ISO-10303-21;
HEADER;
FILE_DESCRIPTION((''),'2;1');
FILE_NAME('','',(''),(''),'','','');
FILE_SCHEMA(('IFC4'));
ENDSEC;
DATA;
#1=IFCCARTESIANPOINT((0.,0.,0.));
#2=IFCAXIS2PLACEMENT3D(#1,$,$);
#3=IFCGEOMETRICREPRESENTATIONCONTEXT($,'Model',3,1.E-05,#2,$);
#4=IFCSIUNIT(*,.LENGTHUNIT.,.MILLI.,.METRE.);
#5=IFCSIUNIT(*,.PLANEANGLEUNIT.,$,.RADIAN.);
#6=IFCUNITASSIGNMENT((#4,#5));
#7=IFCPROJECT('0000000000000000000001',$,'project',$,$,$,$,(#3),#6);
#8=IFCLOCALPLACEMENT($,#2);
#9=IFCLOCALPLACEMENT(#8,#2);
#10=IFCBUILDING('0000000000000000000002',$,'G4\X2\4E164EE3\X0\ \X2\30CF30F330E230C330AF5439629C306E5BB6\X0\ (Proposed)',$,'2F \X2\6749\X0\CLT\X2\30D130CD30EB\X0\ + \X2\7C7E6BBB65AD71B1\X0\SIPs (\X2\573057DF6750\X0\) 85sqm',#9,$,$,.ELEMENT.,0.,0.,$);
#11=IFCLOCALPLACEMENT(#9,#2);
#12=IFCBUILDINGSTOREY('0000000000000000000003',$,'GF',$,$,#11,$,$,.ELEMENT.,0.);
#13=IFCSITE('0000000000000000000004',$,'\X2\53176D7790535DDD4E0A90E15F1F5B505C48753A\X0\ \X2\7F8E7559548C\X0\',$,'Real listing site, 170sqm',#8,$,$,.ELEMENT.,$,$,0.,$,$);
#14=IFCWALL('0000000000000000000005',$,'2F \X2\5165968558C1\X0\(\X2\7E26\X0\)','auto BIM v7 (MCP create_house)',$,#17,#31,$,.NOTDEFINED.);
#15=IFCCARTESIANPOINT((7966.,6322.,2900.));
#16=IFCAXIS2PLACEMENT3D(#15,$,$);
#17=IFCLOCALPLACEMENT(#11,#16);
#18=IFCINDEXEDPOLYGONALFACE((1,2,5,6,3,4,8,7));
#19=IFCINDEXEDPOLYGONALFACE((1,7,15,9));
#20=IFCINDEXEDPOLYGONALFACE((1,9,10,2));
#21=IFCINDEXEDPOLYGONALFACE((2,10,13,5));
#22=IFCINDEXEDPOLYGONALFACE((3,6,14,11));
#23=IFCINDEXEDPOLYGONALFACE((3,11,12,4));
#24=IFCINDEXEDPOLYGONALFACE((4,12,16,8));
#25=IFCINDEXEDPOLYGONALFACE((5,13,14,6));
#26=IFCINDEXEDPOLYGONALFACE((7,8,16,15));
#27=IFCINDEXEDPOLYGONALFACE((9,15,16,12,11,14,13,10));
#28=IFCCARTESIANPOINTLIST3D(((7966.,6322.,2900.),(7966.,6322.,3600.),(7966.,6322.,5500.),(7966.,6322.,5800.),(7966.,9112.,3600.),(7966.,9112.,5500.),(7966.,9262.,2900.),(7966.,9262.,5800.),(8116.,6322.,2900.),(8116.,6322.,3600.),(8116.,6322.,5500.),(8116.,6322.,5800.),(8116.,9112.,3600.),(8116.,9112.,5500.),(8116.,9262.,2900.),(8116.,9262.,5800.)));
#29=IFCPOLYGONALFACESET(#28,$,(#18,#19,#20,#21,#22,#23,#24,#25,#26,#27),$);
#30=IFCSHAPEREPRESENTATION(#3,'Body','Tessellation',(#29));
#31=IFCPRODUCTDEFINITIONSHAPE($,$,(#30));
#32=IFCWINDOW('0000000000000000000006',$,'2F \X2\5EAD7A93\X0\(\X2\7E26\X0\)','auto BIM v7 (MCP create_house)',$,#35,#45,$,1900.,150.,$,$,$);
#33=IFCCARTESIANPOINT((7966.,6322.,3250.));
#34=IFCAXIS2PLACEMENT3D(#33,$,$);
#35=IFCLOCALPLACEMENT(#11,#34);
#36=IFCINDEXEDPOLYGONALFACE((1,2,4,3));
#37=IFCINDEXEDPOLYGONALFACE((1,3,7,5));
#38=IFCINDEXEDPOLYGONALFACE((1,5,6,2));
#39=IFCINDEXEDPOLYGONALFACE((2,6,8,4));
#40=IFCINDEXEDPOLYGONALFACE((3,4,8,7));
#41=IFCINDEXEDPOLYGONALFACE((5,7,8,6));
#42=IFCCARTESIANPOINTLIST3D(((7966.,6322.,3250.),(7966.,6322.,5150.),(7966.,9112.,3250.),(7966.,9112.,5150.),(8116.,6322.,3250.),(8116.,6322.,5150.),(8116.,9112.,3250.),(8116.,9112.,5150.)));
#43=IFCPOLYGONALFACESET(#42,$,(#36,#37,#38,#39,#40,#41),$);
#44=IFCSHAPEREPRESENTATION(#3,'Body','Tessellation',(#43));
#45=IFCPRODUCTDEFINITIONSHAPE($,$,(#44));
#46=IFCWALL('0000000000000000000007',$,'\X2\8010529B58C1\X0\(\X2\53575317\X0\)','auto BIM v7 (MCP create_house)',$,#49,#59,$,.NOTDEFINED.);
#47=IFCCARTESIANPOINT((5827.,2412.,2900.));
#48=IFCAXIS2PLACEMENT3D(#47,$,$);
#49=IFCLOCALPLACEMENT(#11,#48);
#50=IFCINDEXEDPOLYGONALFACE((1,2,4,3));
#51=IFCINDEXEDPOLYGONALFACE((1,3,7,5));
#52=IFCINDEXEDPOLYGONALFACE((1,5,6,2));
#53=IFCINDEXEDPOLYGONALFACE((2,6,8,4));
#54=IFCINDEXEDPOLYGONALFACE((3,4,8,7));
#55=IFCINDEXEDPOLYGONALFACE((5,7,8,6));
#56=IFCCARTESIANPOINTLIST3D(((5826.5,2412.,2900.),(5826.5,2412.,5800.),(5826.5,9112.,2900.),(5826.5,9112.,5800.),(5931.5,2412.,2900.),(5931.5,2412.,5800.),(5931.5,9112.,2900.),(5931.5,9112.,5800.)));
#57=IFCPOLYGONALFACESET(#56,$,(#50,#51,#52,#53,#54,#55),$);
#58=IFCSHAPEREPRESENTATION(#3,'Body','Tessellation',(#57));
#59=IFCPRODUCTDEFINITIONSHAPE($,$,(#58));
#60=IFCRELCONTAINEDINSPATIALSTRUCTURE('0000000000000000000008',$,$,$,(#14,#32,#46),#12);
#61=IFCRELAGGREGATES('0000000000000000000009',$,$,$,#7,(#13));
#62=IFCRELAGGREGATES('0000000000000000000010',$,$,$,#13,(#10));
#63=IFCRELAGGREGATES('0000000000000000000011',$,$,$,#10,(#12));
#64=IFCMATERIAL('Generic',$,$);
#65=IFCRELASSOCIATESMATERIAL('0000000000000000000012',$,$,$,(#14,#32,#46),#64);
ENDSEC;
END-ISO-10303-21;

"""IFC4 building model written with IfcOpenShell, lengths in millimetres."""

from ifc_helpers import new_model, si_unit, frame, frame_2d, origin, place, context, project, spatial, rectangle, extrude, material, element, fill, save


model = new_model("IFC4")

# Units and contexts
model_context = context("Model", 3, precision=1e-05, world=origin())
ifc_project = project(units=[si_unit("LENGTHUNIT", "METRE", prefix="MILLI"), si_unit("PLANEANGLEUNIT", "RADIAN")], contexts=[model_context])

# Site, building, storey
site_placement = place(None, origin())
site = spatial("IfcSite", under=ifc_project, at=site_placement, Name="北海道川上郡弟子屈町 美留和", ObjectType="Real listing site, 170sqm", CompositionType="ELEMENT", RefElevation=0.0)
building_placement = place(site_placement, origin())
building = spatial("IfcBuilding", under=site, at=building_placement, Name="G4世代 ハンモック吹抜の家 (Proposed)", ObjectType="2F 杉CLTパネル + 籾殻断熱SIPs (地域材) 85sqm", CompositionType="ELEMENT", ElevationOfRefHeight=0.0, ElevationOfTerrain=0.0)
storey_placement = place(building_placement, origin())
storey = spatial("IfcBuildingStorey", under=building, at=storey_placement, Name="GF", CompositionType="ELEMENT", Elevation=0.0)

# Shared definitions
ifc_material = material(Name="Generic")

# Wall, opening, window
wall_1_placement = place(storey_placement, frame((7966.0, 6322.0, 2900.0)))
wall_1 = element("IfcWall", 1, at=wall_1_placement, inside=storey, material=ifc_material, Name="2F 入隅壁(縦)", Description="auto BIM v7 (MCP create_house)", PredefinedType="NOTDEFINED", context=model_context, shape_type="SweptSolid", body=[
    extrude(rectangle(XDim=150.0, YDim=2940.0, at=frame_2d((75.0, 1470.0))), frame((7966.0, 6322.0, 2900.0)), (0.0, 0.0, 1.0), 2900.0),
])
opening_1_placement = place(storey_placement, frame((7966.0, 6322.0, 3250.0)))
opening_1 = element("IfcOpeningElement", 2, at=opening_1_placement, cuts=wall_1, PredefinedType="NOTDEFINED", context=model_context, shape_type="SweptSolid", body=[
    extrude(rectangle(XDim=150.0, YDim=2790.0, at=frame_2d((75.0, 1395.0))), frame((7966.0, 6322.0, 3250.0)), (0.0, 0.0, 1.0), 1900.0),
])
window_1_placement = place(storey_placement, frame((7966.0, 6322.0, 3250.0)))
window_1 = element("IfcWindow", 3, at=window_1_placement, inside=storey, material=ifc_material, Name="2F 庭窓(縦)", Description="auto BIM v7 (MCP create_house)", OverallHeight=1900.0, OverallWidth=150.0, context=model_context, shape_type="SweptSolid", body=[
    extrude(rectangle(XDim=150.0, YDim=2790.0, at=frame_2d((75.0, 1395.0))), frame((7966.0, 6322.0, 3250.0)), (0.0, 0.0, 1.0), 1900.0),
])
fill(opening_1, window_1)

# Wall
wall_2_placement = place(storey_placement, frame((5827.0, 2412.0, 2900.0)))
element("IfcWall", 4, at=wall_2_placement, inside=storey, material=ifc_material, Name="耐力壁(南北)", Description="auto BIM v7 (MCP create_house)", PredefinedType="NOTDEFINED", context=model_context, shape_type="SweptSolid", body=[
    extrude(rectangle(XDim=105.0, YDim=6700.0, at=frame_2d((52.0, 3350.0))), frame((5827.0, 2412.0, 2900.0)), (0.0, 0.0, 1.0), 2900.0),
])

save(model, "model.ifc")
